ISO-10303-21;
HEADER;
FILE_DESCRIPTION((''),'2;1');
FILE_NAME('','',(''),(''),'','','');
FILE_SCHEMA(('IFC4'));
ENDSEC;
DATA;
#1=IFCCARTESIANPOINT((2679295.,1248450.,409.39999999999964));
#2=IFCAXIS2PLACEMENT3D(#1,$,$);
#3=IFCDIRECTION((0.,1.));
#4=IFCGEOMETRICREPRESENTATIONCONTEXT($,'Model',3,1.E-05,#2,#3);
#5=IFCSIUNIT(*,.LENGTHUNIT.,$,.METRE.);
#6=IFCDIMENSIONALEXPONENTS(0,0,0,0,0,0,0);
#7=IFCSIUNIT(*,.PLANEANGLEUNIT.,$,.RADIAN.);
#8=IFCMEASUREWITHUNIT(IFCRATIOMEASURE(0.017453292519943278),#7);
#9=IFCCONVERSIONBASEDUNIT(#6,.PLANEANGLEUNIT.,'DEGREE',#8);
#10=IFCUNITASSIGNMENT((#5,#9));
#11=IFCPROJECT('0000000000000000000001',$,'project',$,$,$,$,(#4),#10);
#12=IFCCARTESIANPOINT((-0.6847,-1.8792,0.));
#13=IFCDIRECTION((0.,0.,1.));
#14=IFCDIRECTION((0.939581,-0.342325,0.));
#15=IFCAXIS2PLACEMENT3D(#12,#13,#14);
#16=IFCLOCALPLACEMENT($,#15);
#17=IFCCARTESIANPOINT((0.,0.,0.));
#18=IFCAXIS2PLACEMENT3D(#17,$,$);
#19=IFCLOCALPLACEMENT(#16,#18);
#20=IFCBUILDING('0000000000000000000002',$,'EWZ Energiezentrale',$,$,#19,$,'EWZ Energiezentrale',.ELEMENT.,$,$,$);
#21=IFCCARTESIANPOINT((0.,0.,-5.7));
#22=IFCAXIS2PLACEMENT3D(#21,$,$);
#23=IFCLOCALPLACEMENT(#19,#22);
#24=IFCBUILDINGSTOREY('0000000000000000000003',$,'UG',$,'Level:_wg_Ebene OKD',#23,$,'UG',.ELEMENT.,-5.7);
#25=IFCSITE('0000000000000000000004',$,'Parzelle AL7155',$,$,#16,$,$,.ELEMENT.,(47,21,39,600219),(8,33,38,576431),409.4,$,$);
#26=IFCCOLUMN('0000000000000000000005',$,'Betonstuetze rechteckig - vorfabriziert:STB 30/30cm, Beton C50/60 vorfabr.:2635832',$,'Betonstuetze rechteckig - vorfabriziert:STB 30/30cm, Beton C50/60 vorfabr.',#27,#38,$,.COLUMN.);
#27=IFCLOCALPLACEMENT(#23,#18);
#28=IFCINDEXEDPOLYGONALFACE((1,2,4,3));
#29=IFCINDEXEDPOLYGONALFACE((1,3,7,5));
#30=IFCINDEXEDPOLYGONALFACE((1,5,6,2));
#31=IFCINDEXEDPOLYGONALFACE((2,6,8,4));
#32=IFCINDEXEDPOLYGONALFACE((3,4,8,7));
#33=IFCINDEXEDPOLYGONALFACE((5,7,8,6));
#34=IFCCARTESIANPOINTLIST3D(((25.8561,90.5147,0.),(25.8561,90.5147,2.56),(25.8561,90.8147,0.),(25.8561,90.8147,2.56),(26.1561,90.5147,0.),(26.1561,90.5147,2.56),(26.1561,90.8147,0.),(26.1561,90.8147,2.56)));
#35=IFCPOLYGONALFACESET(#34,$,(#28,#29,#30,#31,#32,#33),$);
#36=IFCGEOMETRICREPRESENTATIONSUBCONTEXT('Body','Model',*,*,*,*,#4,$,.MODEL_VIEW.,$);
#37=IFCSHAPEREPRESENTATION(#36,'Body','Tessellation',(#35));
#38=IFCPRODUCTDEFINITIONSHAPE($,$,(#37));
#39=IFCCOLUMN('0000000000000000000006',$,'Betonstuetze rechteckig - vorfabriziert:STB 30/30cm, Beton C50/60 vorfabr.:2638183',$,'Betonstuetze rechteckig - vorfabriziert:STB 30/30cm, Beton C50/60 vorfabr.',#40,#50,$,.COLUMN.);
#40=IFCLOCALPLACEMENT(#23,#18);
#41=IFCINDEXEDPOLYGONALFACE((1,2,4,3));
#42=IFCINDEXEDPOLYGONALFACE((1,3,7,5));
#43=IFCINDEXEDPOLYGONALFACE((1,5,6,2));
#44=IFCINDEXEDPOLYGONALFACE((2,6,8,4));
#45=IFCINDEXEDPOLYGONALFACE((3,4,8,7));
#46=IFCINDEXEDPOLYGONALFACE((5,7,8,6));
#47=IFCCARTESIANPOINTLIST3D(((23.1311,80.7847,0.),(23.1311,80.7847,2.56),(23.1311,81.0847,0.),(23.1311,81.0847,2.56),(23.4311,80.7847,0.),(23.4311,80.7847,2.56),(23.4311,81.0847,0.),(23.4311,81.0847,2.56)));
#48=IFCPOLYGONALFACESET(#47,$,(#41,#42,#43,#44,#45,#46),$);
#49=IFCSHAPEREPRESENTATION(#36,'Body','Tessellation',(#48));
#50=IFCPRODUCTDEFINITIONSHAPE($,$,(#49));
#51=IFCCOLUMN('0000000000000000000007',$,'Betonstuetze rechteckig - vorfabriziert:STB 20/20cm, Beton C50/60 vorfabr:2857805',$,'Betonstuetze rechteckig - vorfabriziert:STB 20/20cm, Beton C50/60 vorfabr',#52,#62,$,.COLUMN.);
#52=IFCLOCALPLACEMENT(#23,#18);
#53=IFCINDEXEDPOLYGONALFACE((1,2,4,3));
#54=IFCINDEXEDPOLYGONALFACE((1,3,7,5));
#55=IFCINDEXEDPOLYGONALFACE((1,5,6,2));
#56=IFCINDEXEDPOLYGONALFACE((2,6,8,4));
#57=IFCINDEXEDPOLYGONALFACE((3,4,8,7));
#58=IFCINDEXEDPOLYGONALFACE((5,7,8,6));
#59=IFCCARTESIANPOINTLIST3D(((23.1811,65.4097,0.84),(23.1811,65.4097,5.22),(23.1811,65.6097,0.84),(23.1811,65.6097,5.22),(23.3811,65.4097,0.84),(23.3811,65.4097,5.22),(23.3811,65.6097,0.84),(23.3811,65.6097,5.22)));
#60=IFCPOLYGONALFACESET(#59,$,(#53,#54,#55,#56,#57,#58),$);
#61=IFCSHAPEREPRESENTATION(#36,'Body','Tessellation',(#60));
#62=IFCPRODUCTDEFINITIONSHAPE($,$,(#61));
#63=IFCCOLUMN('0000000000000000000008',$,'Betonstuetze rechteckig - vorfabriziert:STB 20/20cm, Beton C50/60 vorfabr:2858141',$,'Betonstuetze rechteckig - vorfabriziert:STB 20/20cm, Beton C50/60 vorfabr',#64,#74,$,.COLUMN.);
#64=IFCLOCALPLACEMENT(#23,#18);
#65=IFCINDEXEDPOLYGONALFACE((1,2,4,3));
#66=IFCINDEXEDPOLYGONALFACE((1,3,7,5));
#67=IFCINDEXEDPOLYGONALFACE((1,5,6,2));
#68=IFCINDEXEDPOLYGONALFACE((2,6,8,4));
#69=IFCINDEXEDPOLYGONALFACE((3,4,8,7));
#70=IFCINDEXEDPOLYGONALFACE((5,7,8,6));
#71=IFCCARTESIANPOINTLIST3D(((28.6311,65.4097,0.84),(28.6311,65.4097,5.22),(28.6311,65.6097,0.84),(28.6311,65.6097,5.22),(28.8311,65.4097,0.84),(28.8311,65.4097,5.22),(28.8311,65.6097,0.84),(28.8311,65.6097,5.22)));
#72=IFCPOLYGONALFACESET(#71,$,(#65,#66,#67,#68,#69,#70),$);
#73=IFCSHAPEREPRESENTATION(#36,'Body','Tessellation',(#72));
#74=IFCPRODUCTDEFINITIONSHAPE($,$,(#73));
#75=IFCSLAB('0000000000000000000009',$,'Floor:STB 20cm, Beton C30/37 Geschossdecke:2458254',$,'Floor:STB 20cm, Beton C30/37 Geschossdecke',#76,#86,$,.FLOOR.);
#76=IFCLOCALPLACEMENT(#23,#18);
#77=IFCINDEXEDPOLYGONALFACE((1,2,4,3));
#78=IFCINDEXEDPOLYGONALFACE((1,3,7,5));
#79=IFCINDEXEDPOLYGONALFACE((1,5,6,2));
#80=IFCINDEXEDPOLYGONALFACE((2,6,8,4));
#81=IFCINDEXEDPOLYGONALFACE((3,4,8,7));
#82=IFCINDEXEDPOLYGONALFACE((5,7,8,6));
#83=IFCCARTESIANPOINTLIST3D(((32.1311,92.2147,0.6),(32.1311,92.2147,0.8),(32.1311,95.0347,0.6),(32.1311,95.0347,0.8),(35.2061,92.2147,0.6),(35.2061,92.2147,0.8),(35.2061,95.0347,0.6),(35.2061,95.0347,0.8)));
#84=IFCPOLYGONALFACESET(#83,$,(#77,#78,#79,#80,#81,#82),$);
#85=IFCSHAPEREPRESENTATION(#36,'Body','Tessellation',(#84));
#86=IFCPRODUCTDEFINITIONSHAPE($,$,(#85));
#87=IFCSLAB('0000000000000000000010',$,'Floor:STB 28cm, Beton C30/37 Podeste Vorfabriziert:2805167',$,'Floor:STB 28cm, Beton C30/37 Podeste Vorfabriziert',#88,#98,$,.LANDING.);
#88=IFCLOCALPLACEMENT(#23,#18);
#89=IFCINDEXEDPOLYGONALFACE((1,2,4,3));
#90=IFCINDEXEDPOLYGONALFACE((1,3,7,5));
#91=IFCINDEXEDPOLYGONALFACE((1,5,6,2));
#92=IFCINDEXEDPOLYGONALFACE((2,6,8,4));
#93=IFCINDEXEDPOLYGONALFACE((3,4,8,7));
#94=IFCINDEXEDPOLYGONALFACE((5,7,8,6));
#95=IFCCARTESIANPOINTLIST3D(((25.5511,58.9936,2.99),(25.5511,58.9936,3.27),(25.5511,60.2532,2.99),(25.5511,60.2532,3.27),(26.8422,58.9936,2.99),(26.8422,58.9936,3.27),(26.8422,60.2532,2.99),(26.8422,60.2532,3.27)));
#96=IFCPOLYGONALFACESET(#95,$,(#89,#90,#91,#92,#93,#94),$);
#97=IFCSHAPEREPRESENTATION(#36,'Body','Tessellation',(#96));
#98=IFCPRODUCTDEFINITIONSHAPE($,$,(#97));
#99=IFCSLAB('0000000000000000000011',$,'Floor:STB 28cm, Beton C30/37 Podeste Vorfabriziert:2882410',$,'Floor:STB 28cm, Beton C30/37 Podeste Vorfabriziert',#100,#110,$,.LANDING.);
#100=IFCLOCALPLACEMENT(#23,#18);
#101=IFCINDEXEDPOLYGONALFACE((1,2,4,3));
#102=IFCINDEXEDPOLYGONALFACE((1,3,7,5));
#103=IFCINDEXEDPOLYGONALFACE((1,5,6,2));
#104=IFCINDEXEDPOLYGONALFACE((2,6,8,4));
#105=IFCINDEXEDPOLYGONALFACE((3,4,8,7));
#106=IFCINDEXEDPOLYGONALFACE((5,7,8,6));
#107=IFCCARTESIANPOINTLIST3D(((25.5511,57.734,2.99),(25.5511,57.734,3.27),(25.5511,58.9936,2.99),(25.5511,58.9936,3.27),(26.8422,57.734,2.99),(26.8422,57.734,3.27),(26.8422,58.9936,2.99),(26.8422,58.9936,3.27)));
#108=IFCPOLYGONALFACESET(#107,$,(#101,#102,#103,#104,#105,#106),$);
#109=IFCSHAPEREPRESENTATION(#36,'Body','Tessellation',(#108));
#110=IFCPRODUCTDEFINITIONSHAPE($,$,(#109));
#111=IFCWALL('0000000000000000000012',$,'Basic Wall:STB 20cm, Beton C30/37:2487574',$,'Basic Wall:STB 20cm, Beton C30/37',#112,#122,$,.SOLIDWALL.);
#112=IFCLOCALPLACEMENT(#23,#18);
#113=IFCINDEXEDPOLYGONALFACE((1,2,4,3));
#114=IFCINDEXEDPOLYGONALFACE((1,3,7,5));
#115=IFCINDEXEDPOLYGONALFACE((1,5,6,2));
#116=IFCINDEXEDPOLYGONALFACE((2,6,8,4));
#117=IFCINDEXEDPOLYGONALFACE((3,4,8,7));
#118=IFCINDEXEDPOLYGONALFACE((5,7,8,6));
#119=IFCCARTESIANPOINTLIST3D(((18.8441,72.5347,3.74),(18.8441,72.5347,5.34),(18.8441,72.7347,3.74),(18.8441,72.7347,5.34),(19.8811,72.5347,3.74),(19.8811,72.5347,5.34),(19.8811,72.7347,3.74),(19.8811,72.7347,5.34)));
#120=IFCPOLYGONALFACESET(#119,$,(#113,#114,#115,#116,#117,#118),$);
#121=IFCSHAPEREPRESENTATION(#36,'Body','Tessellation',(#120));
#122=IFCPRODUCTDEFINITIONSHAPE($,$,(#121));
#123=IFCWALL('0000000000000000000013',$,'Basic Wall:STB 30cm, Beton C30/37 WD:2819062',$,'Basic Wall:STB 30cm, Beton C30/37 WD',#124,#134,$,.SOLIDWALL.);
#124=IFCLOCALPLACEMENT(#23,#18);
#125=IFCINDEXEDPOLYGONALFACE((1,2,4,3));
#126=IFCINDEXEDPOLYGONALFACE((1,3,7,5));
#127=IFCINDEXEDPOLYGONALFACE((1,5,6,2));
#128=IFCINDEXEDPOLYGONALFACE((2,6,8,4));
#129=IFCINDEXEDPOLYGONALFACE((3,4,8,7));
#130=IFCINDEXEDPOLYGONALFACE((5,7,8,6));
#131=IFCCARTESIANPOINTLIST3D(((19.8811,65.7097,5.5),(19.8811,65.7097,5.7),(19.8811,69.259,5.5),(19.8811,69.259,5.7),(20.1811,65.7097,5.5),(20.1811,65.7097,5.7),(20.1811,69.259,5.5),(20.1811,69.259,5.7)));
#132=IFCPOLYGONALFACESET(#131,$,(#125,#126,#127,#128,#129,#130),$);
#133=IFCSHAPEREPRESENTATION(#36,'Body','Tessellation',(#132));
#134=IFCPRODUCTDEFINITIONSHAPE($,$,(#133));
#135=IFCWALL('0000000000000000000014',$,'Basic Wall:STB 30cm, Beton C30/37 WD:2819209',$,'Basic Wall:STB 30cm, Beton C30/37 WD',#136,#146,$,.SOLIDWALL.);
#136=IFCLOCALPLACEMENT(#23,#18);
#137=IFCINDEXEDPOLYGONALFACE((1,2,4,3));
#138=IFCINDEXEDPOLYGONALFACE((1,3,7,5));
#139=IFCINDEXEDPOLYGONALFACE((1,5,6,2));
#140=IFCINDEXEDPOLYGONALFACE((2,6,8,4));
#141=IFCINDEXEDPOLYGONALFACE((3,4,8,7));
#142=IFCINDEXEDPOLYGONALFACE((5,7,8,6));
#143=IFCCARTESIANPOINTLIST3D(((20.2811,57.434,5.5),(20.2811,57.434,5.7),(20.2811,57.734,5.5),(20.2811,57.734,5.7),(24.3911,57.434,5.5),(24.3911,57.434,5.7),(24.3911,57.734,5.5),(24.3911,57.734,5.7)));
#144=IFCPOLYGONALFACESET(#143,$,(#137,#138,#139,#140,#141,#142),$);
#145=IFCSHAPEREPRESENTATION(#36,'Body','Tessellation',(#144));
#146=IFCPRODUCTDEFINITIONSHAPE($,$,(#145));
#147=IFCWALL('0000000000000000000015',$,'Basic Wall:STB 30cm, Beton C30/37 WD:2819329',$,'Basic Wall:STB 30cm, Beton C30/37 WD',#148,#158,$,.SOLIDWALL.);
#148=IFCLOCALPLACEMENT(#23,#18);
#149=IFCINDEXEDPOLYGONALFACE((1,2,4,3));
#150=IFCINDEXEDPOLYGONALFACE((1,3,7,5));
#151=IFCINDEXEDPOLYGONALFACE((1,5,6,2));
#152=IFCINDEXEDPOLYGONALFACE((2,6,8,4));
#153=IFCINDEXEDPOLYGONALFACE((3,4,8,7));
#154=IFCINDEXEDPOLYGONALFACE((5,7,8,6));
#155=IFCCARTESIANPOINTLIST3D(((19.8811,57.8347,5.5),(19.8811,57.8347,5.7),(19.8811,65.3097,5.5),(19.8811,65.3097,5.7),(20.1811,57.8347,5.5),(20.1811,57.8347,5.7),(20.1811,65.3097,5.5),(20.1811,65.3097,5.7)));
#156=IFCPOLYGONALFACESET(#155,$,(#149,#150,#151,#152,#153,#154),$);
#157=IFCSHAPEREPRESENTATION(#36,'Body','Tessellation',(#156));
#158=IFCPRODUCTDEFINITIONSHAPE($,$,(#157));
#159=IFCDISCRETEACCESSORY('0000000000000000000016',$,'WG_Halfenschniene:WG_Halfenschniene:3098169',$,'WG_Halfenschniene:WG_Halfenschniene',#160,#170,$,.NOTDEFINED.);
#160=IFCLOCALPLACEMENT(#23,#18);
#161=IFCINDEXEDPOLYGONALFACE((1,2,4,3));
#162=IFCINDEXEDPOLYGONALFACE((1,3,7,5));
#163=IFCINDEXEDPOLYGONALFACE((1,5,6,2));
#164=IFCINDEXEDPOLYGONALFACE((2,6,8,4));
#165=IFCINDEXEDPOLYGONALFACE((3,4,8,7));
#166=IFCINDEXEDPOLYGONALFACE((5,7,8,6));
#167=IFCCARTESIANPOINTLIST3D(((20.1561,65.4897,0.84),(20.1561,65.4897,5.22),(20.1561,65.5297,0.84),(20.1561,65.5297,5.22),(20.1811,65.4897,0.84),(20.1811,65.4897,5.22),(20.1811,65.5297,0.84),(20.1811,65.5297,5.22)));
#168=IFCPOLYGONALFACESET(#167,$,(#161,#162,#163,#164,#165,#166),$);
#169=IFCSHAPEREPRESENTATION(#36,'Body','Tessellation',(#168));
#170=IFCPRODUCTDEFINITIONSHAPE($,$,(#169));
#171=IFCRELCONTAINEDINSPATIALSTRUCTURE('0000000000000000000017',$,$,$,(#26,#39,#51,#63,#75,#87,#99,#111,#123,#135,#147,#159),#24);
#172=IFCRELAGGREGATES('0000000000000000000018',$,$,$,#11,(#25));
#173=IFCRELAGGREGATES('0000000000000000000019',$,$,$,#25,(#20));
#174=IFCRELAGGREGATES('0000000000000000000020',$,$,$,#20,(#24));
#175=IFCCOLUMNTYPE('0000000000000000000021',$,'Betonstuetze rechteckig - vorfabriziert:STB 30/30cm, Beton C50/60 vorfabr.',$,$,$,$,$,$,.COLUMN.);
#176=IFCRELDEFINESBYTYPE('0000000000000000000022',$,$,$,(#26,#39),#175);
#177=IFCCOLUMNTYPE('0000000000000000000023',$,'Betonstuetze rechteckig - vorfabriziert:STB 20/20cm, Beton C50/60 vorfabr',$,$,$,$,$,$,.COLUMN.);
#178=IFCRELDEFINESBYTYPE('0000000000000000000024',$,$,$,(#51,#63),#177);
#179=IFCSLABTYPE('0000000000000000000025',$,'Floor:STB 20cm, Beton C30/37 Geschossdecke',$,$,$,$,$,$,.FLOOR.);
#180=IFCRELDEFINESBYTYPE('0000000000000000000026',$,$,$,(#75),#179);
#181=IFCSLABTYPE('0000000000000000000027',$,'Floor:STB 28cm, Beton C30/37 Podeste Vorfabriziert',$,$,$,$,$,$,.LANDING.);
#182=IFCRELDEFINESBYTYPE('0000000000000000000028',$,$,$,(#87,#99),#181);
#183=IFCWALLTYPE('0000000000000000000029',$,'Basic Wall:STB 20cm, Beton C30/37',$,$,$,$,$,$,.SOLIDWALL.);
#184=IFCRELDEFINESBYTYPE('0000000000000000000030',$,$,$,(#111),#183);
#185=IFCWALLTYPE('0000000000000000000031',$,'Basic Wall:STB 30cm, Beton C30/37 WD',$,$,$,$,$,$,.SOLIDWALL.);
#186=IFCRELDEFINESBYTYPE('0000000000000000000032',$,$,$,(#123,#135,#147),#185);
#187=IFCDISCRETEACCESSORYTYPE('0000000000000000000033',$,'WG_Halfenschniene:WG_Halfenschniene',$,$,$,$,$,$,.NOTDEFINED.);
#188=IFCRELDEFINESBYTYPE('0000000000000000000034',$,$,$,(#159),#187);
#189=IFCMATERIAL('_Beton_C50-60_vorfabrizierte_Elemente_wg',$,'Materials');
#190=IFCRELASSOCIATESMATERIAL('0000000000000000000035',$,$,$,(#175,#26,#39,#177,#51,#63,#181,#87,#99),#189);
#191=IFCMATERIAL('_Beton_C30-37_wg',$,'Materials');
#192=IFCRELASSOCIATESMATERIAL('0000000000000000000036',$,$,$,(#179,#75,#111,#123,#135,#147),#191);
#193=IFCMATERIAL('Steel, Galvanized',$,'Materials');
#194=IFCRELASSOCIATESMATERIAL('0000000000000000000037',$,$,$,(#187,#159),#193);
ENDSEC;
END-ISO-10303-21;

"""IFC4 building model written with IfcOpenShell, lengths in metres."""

from ifc_helpers import new_model, entity, si_unit, converted_unit, direction, frame, origin, place, context, subcontext, project, spatial, indexed_curve, outline, extrude, source, transform, mapped, material, type_object, type_shapes, element, save


model = new_model("IFC4")

# Units and contexts
model_context = context("Model", 3, precision=1e-05, world=frame((2679295.0, 1248450.0, 409.39999999999964)), true_north=direction((0.0, 1.0)))
body_context = subcontext(model_context, "Body", "Model", "MODEL_VIEW")
ifc_project = project(units=[si_unit("LENGTHUNIT", "METRE"), converted_unit("PLANEANGLEUNIT", "DEGREE", entity("IfcRatioMeasure", 0.017453292519943278), si_unit("PLANEANGLEUNIT", "RADIAN"), dimensions=[0, 0, 0, 0, 0, 0, 0])], contexts=[model_context])

# Site, building, storey
site_placement = place(None, frame((-0.6847, -1.8792, 0.0), z_axis=(0.0, 0.0, 1.0), x_axis=(0.939581, -0.342325, 0.0)))
site = spatial("IfcSite", under=ifc_project, at=site_placement, Name="Parzelle AL7155", CompositionType="ELEMENT", RefLatitude=(47, 21, 39, 600219), RefLongitude=(8, 33, 38, 576431), RefElevation=409.4)
building_placement = place(site_placement, origin())
building = spatial("IfcBuilding", under=site, at=building_placement, Name="EWZ Energiezentrale", LongName="EWZ Energiezentrale", CompositionType="ELEMENT")
storey_placement = place(building_placement, frame((0.0, 0.0, -5.7)))
storey = spatial("IfcBuildingStorey", under=building, at=storey_placement, Name="UG", ObjectType="Level:_wg_Ebene OKD", LongName="UG", CompositionType="ELEMENT", Elevation=-5.7)

# Columns
ifc_material_1 = material(Name="_Beton_C50-60_vorfabrizierte_Elemente_wg", Category="Materials")
column_type_1 = type_object("IfcColumnType", Name="Betonstuetze rechteckig - vorfabriziert:STB 30/30cm, Beton C50/60 vorfabr.", PredefinedType="COLUMN", material=ifc_material_1)
shared_shape_1 = source(origin(), body_context, "Body", "SweptSolid", [
    extrude(outline(indexed_curve([(-0.15, -0.15), (0.15, -0.15), (0.15, 0.15), (-0.15, 0.15), (-0.15, -0.15)], self_intersect=False)), frame((26.0061, 90.6647, -5.7), z_axis=(0.0, 0.0, 1.0), x_axis=(0.0, -1.0, 0.0)), (0.0, 0.0, 1.0), 2.56),
])
type_shapes(column_type_1, [shared_shape_1])
column_1_placement = place(storey_placement, frame((0.0, 0.0, 5.7), z_axis=(0.0, 0.0, 1.0), x_axis=(1.0, 0.0, 0.0)))
element("IfcColumn", 1, at=column_1_placement, inside=storey, type_object=column_type_1, material=ifc_material_1, Name="Betonstuetze rechteckig - vorfabriziert:STB 30/30cm, Beton C50/60 vorfabr.:2635832", ObjectType="Betonstuetze rechteckig - vorfabriziert:STB 30/30cm, Beton C50/60 vorfabr.", PredefinedType="COLUMN", context=body_context, shape_type="MappedRepresentation", body=[
    mapped(shared_shape_1, transform((0.0, 0.0, 0.0), scale=1.0)),
])
shared_shape_2 = source(origin(), body_context, "Body", "SweptSolid", [
    extrude(outline(indexed_curve([(-0.15, -0.15), (0.15, -0.15), (0.15, 0.15), (-0.15, 0.15), (-0.15, -0.15)], self_intersect=False)), frame((23.2811, 80.9347, -5.7), z_axis=(0.0, 0.0, 1.0), x_axis=(0.0, -1.0, 0.0)), (0.0, 0.0, 1.0), 2.56),
])
column_2_placement = place(storey_placement, frame((0.0, 0.0, 5.7)))
element("IfcColumn", 2, at=column_2_placement, inside=storey, type_object=column_type_1, material=ifc_material_1, Name="Betonstuetze rechteckig - vorfabriziert:STB 30/30cm, Beton C50/60 vorfabr.:2638183", ObjectType="Betonstuetze rechteckig - vorfabriziert:STB 30/30cm, Beton C50/60 vorfabr.", PredefinedType="COLUMN", context=body_context, shape_type="MappedRepresentation", body=[
    mapped(shared_shape_2, transform((0.0, 0.0, 0.0), scale=1.0)),
])
column_type_2 = type_object("IfcColumnType", Name="Betonstuetze rechteckig - vorfabriziert:STB 20/20cm, Beton C50/60 vorfabr", PredefinedType="COLUMN", material=ifc_material_1)
shared_shape_3 = source(origin(), body_context, "Body", "SweptSolid", [
    extrude(outline(indexed_curve([(-0.1, -0.1), (0.1, -0.1), (0.1, 0.1), (-0.1, 0.1), (-0.1, -0.1)], self_intersect=False)), frame((23.2811, 65.5097, -4.86), z_axis=(0.0, 0.0, 1.0), x_axis=(0.0, -1.0, 0.0)), (0.0, 0.0, 1.0), 4.38),
])
type_shapes(column_type_2, [shared_shape_3])
column_3_placement = place(storey_placement, frame((0.0, 0.0, 5.7)))
element("IfcColumn", 3, at=column_3_placement, inside=storey, type_object=column_type_2, material=ifc_material_1, Name="Betonstuetze rechteckig - vorfabriziert:STB 20/20cm, Beton C50/60 vorfabr:2857805", ObjectType="Betonstuetze rechteckig - vorfabriziert:STB 20/20cm, Beton C50/60 vorfabr", PredefinedType="COLUMN", context=body_context, shape_type="MappedRepresentation", body=[
    mapped(shared_shape_3, transform((0.0, 0.0, 0.0), scale=1.0)),
])
shared_shape_4 = source(origin(), body_context, "Body", "SweptSolid", [
    extrude(outline(indexed_curve([(-0.1, -0.1), (0.1, -0.1), (0.1, 0.1), (-0.1, 0.1), (-0.1, -0.1)], self_intersect=False)), frame((28.7311, 65.5097, -4.86), z_axis=(0.0, 0.0, 1.0), x_axis=(0.0, -1.0, 0.0)), (0.0, 0.0, 1.0), 4.38),
])
column_4_placement = place(storey_placement, frame((0.0, 0.0, 5.7)))
element("IfcColumn", 4, at=column_4_placement, inside=storey, type_object=column_type_2, material=ifc_material_1, Name="Betonstuetze rechteckig - vorfabriziert:STB 20/20cm, Beton C50/60 vorfabr:2858141", ObjectType="Betonstuetze rechteckig - vorfabriziert:STB 20/20cm, Beton C50/60 vorfabr", PredefinedType="COLUMN", context=body_context, shape_type="MappedRepresentation", body=[
    mapped(shared_shape_4, transform((0.0, 0.0, 0.0), scale=1.0)),
])

# Shared definitions
ifc_material_2 = material(Name="_Beton_C30-37_wg", Category="Materials")

# Slabs
slab_type_1 = type_object("IfcSlabType", Name="Floor:STB 20cm, Beton C30/37 Geschossdecke", PredefinedType="FLOOR", material=ifc_material_2)
slab_1_placement = place(storey_placement, frame((0.0, 0.0, 0.0), z_axis=(0.0, 0.0, 1.0), x_axis=(1.0, 0.0, 0.0)))
element("IfcSlab", 5, at=slab_1_placement, inside=storey, type_object=slab_type_1, material=ifc_material_2, Name="Floor:STB 20cm, Beton C30/37 Geschossdecke:2458254", ObjectType="Floor:STB 20cm, Beton C30/37 Geschossdecke", PredefinedType="FLOOR", context=body_context, shape_type="SweptSolid", body=[
    extrude(outline(indexed_curve([(-1.41, -1.5375), (1.41, -1.5375), (1.41, 1.5375), (-1.41, 1.5375), (-1.41, -1.5375)], self_intersect=False)), frame((33.6686, 93.6247, 0.8), z_axis=(0.0, 0.0, -1.0), x_axis=(0.0, 1.0, 0.0)), (0.0, 0.0, 1.0), 0.2),
])
slab_type_2 = type_object("IfcSlabType", Name="Floor:STB 28cm, Beton C30/37 Podeste Vorfabriziert", PredefinedType="LANDING", material=ifc_material_1)
slab_2_placement = place(storey_placement, frame((0.0, 0.0, 0.0), z_axis=(0.0, 0.0, 1.0), x_axis=(1.0, 0.0, 0.0)))
element("IfcSlab", 6, at=slab_2_placement, inside=storey, type_object=slab_type_2, material=ifc_material_1, Name="Floor:STB 28cm, Beton C30/37 Podeste Vorfabriziert:2805167", ObjectType="Floor:STB 28cm, Beton C30/37 Podeste Vorfabriziert", PredefinedType="LANDING", context=body_context, shape_type="SweptSolid", body=[
    extrude(outline(indexed_curve([(-0.6298, -0.6455), (0.6298, -0.6455), (0.6298, 0.6455), (-0.6298, 0.6455), (-0.6298, -0.6455)], self_intersect=False)), frame((26.1966, 59.6234, 3.27), z_axis=(0.0, 0.0, -1.0), x_axis=(0.0, 1.0, 0.0)), (0.0, 0.0, 1.0), 0.28),
])
slab_3_placement = place(storey_placement, frame((0.0, 0.0, 0.0), z_axis=(0.0, 0.0, 1.0), x_axis=(1.0, 0.0, 0.0)))
element("IfcSlab", 7, at=slab_3_placement, inside=storey, type_object=slab_type_2, material=ifc_material_1, Name="Floor:STB 28cm, Beton C30/37 Podeste Vorfabriziert:2882410", ObjectType="Floor:STB 28cm, Beton C30/37 Podeste Vorfabriziert", PredefinedType="LANDING", context=body_context, shape_type="SweptSolid", body=[
    extrude(outline(indexed_curve([(-0.6298, -0.6455), (0.6298, -0.6455), (0.6298, 0.6455), (-0.6298, 0.6455), (-0.6298, -0.6455)], self_intersect=False)), frame((26.1966, 58.3638, 3.27), z_axis=(0.0, 0.0, -1.0), x_axis=(0.0, 1.0, 0.0)), (0.0, 0.0, 1.0), 0.28),
])

# Walls
wall_type_1 = type_object("IfcWallType", Name="Basic Wall:STB 20cm, Beton C30/37", PredefinedType="SOLIDWALL")
wall_1_placement = place(storey_placement, frame((18.8441, 72.6347, 3.74)))
element("IfcWall", 8, at=wall_1_placement, inside=storey, type_object=wall_type_1, material=ifc_material_2, Name="Basic Wall:STB 20cm, Beton C30/37:2487574", ObjectType="Basic Wall:STB 20cm, Beton C30/37", PredefinedType="SOLIDWALL", context=body_context, shape_type="SweptSolid", body=[
    extrude(outline(indexed_curve([(1.037, 0.1), (0.0, 0.1), (0.0, -0.1), (1.037, -0.1), (1.037, 0.1)], self_intersect=False)), origin(), (0.0, 0.0, 1.0), 1.6),
])
wall_type_2 = type_object("IfcWallType", Name="Basic Wall:STB 30cm, Beton C30/37 WD", PredefinedType="SOLIDWALL")
wall_2_placement = place(storey_placement, frame((20.0311, 65.7097, 5.5), z_axis=(0.0, 0.0, 1.0), x_axis=(0.0, 1.0, 0.0)))
element("IfcWall", 9, at=wall_2_placement, inside=storey, type_object=wall_type_2, material=ifc_material_2, Name="Basic Wall:STB 30cm, Beton C30/37 WD:2819062", ObjectType="Basic Wall:STB 30cm, Beton C30/37 WD", PredefinedType="SOLIDWALL", context=body_context, shape_type="SweptSolid", body=[
    extrude(outline(indexed_curve([(3.5494, 0.15), (0.0, 0.15), (0.0, -0.15), (3.5494, -0.15), (3.5494, 0.15)], self_intersect=False)), origin(), (0.0, 0.0, 1.0), 0.2),
])
wall_3_placement = place(storey_placement, frame((24.3911, 57.584, 5.5), z_axis=(0.0, 0.0, 1.0), x_axis=(-1.0, 0.0, 0.0)))
element("IfcWall", 10, at=wall_3_placement, inside=storey, type_object=wall_type_2, material=ifc_material_2, Name="Basic Wall:STB 30cm, Beton C30/37 WD:2819209", ObjectType="Basic Wall:STB 30cm, Beton C30/37 WD", PredefinedType="SOLIDWALL", context=body_context, shape_type="SweptSolid", body=[
    extrude(outline(indexed_curve([(4.11, 0.15), (0.0, 0.15), (0.0, -0.15), (4.11, -0.15), (4.11, 0.15)], self_intersect=False)), origin(), (0.0, 0.0, 1.0), 0.2),
])
wall_4_placement = place(storey_placement, frame((20.0311, 57.8347, 5.5), z_axis=(0.0, 0.0, 1.0), x_axis=(0.0, 1.0, 0.0)))
element("IfcWall", 11, at=wall_4_placement, inside=storey, type_object=wall_type_2, material=ifc_material_2, Name="Basic Wall:STB 30cm, Beton C30/37 WD:2819329", ObjectType="Basic Wall:STB 30cm, Beton C30/37 WD", PredefinedType="SOLIDWALL", context=body_context, shape_type="SweptSolid", body=[
    extrude(outline(indexed_curve([(7.475, 0.15), (0.0, 0.15), (0.0, -0.15), (7.475, -0.15), (7.475, 0.15)], self_intersect=False)), origin(), (0.0, 0.0, 1.0), 0.2),
])

# Discrete accessory
ifc_material_3 = material(Name="Steel, Galvanized", Category="Materials")
discrete_accessory_type = type_object("IfcDiscreteAccessoryType", Name="WG_Halfenschniene:WG_Halfenschniene", PredefinedType="NOTDEFINED", material=ifc_material_3)
shared_shape_5 = source(origin(), body_context, "Body", "SweptSolid", [
    extrude(outline(indexed_curve([(-2.19, -0.02), (2.19, -0.02), (2.19, 0.02), (-2.19, 0.02), (-2.19, -0.02)], self_intersect=False)), frame((2.19, 0.0, -0.0125)), (0.0, 0.0, 1.0), 0.025),
])
discrete_accessory_placement = place(storey_placement, frame((20.1686, 65.5097, 5.22), z_axis=(1.0, 0.0, 0.0), x_axis=(0.0, 0.0, -1.0)))
element("IfcDiscreteAccessory", 12, at=discrete_accessory_placement, inside=storey, type_object=discrete_accessory_type, material=ifc_material_3, Name="WG_Halfenschniene:WG_Halfenschniene:3098169", ObjectType="WG_Halfenschniene:WG_Halfenschniene", PredefinedType="NOTDEFINED", context=body_context, shape_type="MappedRepresentation", body=[
    mapped(shared_shape_5, transform((0.0, 0.0, 0.0), scale=1.0)),
])

save(model, "model.ifc")
